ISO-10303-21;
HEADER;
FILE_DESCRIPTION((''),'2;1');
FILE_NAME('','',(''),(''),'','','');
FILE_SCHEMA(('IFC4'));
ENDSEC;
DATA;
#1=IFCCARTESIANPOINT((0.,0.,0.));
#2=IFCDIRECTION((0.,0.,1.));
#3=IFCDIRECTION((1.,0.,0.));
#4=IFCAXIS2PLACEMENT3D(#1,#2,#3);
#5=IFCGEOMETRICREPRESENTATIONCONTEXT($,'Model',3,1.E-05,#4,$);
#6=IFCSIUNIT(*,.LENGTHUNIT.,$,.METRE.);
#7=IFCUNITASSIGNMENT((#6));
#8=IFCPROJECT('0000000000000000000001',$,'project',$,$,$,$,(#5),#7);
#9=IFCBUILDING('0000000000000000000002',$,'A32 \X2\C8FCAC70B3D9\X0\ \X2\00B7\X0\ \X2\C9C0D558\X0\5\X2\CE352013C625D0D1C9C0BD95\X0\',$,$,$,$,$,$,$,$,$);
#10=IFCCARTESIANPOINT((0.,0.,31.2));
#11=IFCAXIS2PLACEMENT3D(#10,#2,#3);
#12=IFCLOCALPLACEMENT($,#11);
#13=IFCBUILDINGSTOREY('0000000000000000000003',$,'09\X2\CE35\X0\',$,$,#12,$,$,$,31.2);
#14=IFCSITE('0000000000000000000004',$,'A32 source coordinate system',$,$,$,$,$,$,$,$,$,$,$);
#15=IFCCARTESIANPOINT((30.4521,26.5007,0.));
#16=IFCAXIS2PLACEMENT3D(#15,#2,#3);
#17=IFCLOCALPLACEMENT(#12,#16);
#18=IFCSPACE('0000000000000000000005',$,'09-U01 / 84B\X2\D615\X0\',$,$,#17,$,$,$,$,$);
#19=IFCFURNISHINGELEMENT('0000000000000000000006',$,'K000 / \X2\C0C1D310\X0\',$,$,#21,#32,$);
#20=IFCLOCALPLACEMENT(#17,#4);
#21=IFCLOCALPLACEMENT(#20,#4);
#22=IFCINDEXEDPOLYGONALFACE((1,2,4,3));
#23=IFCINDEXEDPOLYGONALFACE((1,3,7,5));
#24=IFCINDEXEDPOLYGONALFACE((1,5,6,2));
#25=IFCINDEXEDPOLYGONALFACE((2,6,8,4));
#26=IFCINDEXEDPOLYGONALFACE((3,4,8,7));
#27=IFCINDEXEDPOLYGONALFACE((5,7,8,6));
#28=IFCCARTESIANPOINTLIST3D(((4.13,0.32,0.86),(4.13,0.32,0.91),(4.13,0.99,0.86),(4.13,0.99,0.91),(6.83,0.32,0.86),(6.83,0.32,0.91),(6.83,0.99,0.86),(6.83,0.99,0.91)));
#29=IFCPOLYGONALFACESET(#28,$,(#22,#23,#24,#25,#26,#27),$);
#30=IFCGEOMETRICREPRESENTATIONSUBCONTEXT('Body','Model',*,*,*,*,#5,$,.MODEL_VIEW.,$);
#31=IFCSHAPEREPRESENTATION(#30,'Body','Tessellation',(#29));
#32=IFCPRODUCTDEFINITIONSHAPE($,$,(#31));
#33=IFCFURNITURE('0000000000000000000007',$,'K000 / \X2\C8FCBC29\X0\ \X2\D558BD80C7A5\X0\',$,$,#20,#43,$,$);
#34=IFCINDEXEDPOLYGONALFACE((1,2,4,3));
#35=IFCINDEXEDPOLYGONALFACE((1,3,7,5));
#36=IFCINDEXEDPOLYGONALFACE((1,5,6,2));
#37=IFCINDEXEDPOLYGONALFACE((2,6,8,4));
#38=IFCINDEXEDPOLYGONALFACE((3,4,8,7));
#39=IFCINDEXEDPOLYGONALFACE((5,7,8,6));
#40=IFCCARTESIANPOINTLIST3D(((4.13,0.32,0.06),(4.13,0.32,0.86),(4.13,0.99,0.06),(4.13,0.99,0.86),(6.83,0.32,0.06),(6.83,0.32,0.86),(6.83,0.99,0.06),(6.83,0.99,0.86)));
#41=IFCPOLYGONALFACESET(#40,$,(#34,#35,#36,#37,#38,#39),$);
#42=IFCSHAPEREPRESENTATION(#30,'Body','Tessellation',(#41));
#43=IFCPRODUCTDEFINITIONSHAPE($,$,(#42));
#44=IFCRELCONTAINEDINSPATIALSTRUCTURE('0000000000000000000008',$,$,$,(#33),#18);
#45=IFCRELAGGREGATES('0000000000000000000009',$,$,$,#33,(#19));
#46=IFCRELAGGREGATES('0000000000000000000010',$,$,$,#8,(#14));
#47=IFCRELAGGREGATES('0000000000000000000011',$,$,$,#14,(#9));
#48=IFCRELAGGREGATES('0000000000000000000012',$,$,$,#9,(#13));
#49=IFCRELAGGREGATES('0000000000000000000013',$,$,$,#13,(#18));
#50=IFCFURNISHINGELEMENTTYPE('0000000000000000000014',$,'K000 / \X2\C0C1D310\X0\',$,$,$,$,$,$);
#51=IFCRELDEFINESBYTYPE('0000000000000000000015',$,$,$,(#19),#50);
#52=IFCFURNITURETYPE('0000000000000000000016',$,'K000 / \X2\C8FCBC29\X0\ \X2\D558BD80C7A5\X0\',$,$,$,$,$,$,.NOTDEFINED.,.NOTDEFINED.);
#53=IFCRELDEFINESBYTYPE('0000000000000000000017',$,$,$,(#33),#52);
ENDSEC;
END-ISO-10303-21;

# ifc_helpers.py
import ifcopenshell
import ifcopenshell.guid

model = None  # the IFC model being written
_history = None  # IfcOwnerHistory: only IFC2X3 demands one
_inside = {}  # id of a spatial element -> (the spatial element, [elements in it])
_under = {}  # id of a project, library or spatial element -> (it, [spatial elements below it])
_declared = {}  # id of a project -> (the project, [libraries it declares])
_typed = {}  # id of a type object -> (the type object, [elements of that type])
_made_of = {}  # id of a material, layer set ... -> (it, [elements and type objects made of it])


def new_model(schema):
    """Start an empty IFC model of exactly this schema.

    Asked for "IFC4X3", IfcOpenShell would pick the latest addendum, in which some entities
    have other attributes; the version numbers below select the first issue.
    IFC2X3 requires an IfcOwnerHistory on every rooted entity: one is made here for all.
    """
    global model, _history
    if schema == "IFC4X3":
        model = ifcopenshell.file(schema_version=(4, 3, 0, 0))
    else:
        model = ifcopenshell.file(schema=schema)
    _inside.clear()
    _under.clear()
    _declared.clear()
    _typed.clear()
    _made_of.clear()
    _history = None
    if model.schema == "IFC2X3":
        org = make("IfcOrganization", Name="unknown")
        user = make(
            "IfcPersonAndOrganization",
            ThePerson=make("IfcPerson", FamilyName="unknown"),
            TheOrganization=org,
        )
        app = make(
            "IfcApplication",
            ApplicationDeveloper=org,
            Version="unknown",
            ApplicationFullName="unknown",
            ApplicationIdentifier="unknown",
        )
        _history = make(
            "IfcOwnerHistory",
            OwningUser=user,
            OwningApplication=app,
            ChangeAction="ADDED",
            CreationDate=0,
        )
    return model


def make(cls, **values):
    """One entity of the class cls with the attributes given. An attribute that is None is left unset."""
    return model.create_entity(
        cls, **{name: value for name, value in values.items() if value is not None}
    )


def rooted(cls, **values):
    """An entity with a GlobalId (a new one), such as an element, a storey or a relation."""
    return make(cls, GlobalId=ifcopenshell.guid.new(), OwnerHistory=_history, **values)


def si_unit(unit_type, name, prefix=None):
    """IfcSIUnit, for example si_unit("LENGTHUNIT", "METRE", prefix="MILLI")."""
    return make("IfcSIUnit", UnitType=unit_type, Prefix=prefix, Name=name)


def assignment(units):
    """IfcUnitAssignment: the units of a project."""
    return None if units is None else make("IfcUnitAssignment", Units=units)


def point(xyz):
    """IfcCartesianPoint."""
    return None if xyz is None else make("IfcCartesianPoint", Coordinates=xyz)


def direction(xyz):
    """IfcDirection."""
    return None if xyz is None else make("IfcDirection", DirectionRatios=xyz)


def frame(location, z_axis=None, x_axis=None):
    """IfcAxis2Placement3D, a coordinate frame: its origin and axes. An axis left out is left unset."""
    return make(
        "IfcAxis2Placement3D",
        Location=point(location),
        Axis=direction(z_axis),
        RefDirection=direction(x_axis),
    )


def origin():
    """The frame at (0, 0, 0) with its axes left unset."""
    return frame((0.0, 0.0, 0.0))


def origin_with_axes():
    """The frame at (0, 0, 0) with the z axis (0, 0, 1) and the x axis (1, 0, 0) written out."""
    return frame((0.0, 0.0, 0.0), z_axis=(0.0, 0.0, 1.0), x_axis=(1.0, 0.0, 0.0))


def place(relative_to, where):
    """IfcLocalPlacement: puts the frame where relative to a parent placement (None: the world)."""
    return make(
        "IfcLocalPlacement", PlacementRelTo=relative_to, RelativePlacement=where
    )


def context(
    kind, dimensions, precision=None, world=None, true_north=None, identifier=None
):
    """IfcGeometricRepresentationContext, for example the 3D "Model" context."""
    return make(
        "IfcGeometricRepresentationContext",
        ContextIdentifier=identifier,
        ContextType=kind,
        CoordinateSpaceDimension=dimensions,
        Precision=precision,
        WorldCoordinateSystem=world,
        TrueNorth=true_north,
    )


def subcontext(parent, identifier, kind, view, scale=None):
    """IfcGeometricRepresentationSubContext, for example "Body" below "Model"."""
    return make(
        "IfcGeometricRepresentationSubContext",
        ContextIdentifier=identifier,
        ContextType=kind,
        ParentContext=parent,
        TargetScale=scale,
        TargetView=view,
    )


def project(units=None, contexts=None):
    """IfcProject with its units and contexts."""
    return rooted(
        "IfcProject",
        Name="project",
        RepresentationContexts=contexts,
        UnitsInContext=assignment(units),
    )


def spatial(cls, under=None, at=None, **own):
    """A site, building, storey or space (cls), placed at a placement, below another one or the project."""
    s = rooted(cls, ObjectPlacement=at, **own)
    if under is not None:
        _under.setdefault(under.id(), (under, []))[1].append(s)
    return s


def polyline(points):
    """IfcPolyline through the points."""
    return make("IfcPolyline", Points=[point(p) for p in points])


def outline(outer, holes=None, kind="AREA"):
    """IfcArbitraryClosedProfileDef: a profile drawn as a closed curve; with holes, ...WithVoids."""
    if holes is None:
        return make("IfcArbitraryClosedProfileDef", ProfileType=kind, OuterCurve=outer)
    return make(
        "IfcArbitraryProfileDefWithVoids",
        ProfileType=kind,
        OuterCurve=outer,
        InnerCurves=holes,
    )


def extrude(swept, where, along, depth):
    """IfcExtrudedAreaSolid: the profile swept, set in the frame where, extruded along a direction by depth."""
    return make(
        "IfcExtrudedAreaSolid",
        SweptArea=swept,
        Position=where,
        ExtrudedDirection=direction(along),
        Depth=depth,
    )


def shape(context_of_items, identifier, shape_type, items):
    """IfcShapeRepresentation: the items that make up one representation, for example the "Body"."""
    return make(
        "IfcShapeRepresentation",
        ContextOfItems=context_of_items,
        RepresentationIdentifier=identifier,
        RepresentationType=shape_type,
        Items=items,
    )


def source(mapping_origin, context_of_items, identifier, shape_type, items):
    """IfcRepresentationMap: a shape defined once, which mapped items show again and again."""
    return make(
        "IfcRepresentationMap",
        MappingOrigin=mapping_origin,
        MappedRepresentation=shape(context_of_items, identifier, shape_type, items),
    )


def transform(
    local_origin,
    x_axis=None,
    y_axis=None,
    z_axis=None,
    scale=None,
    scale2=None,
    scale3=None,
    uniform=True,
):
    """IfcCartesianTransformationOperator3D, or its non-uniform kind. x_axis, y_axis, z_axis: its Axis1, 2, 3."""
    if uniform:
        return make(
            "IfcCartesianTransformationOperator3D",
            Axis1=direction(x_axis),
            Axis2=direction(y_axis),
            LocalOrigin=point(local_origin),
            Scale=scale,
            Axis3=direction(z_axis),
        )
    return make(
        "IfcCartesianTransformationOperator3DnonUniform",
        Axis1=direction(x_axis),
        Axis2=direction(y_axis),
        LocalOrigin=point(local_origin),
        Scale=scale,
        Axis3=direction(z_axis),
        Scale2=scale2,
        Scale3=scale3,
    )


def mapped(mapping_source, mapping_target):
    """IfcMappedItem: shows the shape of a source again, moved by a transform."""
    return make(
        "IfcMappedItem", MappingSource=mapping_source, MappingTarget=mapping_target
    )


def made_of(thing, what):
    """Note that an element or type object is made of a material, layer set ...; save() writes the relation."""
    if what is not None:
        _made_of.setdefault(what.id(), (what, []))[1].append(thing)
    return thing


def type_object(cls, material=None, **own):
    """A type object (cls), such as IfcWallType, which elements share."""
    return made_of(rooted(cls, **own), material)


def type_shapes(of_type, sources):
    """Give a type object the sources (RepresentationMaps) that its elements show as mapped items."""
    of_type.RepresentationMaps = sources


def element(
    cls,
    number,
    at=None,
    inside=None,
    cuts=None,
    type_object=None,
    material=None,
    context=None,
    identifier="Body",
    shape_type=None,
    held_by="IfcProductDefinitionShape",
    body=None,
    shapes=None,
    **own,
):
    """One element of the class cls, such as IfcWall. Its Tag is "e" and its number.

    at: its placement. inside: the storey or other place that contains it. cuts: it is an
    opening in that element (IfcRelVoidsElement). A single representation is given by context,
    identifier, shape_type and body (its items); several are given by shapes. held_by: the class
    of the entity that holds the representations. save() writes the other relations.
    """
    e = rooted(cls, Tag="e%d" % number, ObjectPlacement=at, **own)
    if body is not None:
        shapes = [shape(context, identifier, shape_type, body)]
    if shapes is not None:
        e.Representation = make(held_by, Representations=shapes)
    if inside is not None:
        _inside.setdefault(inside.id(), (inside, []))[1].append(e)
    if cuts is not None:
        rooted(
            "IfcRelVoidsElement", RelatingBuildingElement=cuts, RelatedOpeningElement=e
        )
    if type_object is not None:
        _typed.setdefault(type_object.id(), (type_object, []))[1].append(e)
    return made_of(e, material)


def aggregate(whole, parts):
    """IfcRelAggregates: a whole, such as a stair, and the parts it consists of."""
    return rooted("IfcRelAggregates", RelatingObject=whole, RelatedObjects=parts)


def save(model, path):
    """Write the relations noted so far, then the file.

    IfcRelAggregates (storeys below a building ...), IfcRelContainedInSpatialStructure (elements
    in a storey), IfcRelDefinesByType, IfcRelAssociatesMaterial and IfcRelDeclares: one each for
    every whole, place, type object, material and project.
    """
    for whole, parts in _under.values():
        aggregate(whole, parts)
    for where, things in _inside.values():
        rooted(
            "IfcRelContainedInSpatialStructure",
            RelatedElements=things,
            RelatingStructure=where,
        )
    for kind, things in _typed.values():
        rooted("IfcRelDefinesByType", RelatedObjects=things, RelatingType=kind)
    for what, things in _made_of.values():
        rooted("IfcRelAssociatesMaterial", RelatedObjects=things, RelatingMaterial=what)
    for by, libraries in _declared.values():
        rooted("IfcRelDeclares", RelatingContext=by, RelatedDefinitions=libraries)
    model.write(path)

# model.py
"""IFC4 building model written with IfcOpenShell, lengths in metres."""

from ifc_helpers import new_model, si_unit, frame, origin, origin_with_axes, place, context, subcontext, project, spatial, polyline, outline, extrude, source, transform, mapped, type_object, type_shapes, element, aggregate, save


model = new_model("IFC4")

# Units and contexts
model_context = context("Model", 3, precision=1e-05, world=origin_with_axes())
body_context = subcontext(model_context, "Body", "Model", "MODEL_VIEW")
ifc_project = project(units=[si_unit("LENGTHUNIT", "METRE")], contexts=[model_context])

# Site, building, storey, space
site = spatial("IfcSite", under=ifc_project, Name="A32 source coordinate system")
building = spatial("IfcBuilding", under=site, Name="A32 주거동 · 지하5층–옥탑지붕")
storey_placement = place(None, frame((0.0, 0.0, 31.2), z_axis=(0.0, 0.0, 1.0), x_axis=(1.0, 0.0, 0.0)))
storey = spatial("IfcBuildingStorey", under=building, at=storey_placement, Name="09층", Elevation=31.2)
space_placement = place(storey_placement, frame((30.4521, 26.5007, 0.0), z_axis=(0.0, 0.0, 1.0), x_axis=(1.0, 0.0, 0.0)))
space = spatial("IfcSpace", under=storey, at=space_placement, Name="09-U01 / 84B형")

# Furnishing element
furnishing_element_type = type_object("IfcFurnishingElementType", Name="K000 / 상판")
shared_shape_1 = source(origin(), body_context, "Body", "SweptSolid", [
    extrude(outline(polyline([(4.13, 0.32), (4.13, 0.99), (6.83, 0.99), (6.83, 0.32), (4.13, 0.32)])), frame((0.0, 0.0, 0.86)), (0.0, 0.0, 1.0), 0.05),
])
type_shapes(furnishing_element_type, [shared_shape_1])
furniture_placement = place(space_placement, origin_with_axes())
furnishing_placement = place(furniture_placement, origin_with_axes())
furnishing = element("IfcFurnishingElement", 1, at=furnishing_placement, type_object=furnishing_element_type, Name="K000 / 상판", context=body_context, shape_type="MappedRepresentation", body=[
    mapped(shared_shape_1, transform((0.0, 0.0, 0.0), scale=1.0)),
])

# Furniture
furniture_type = type_object("IfcFurnitureType", Name="K000 / 주방 하부장", AssemblyPlace="NOTDEFINED", PredefinedType="NOTDEFINED")
shared_shape_2 = source(origin(), body_context, "Body", "SweptSolid", [
    extrude(outline(polyline([(6.83, 0.32), (4.13, 0.32), (4.13, 0.99), (6.83, 0.99), (6.83, 0.32)])), frame((0.0, 0.0, 0.06)), (0.0, 0.0, 1.0), 0.8),
])
type_shapes(furniture_type, [shared_shape_2])
furniture = element("IfcFurniture", 2, at=furniture_placement, inside=space, type_object=furniture_type, Name="K000 / 주방 하부장", context=body_context, shape_type="MappedRepresentation", body=[
    mapped(shared_shape_2, transform((0.0, 0.0, 0.0), scale=1.0)),
])
aggregate(furniture, [furnishing])

save(model, "model.ifc")
